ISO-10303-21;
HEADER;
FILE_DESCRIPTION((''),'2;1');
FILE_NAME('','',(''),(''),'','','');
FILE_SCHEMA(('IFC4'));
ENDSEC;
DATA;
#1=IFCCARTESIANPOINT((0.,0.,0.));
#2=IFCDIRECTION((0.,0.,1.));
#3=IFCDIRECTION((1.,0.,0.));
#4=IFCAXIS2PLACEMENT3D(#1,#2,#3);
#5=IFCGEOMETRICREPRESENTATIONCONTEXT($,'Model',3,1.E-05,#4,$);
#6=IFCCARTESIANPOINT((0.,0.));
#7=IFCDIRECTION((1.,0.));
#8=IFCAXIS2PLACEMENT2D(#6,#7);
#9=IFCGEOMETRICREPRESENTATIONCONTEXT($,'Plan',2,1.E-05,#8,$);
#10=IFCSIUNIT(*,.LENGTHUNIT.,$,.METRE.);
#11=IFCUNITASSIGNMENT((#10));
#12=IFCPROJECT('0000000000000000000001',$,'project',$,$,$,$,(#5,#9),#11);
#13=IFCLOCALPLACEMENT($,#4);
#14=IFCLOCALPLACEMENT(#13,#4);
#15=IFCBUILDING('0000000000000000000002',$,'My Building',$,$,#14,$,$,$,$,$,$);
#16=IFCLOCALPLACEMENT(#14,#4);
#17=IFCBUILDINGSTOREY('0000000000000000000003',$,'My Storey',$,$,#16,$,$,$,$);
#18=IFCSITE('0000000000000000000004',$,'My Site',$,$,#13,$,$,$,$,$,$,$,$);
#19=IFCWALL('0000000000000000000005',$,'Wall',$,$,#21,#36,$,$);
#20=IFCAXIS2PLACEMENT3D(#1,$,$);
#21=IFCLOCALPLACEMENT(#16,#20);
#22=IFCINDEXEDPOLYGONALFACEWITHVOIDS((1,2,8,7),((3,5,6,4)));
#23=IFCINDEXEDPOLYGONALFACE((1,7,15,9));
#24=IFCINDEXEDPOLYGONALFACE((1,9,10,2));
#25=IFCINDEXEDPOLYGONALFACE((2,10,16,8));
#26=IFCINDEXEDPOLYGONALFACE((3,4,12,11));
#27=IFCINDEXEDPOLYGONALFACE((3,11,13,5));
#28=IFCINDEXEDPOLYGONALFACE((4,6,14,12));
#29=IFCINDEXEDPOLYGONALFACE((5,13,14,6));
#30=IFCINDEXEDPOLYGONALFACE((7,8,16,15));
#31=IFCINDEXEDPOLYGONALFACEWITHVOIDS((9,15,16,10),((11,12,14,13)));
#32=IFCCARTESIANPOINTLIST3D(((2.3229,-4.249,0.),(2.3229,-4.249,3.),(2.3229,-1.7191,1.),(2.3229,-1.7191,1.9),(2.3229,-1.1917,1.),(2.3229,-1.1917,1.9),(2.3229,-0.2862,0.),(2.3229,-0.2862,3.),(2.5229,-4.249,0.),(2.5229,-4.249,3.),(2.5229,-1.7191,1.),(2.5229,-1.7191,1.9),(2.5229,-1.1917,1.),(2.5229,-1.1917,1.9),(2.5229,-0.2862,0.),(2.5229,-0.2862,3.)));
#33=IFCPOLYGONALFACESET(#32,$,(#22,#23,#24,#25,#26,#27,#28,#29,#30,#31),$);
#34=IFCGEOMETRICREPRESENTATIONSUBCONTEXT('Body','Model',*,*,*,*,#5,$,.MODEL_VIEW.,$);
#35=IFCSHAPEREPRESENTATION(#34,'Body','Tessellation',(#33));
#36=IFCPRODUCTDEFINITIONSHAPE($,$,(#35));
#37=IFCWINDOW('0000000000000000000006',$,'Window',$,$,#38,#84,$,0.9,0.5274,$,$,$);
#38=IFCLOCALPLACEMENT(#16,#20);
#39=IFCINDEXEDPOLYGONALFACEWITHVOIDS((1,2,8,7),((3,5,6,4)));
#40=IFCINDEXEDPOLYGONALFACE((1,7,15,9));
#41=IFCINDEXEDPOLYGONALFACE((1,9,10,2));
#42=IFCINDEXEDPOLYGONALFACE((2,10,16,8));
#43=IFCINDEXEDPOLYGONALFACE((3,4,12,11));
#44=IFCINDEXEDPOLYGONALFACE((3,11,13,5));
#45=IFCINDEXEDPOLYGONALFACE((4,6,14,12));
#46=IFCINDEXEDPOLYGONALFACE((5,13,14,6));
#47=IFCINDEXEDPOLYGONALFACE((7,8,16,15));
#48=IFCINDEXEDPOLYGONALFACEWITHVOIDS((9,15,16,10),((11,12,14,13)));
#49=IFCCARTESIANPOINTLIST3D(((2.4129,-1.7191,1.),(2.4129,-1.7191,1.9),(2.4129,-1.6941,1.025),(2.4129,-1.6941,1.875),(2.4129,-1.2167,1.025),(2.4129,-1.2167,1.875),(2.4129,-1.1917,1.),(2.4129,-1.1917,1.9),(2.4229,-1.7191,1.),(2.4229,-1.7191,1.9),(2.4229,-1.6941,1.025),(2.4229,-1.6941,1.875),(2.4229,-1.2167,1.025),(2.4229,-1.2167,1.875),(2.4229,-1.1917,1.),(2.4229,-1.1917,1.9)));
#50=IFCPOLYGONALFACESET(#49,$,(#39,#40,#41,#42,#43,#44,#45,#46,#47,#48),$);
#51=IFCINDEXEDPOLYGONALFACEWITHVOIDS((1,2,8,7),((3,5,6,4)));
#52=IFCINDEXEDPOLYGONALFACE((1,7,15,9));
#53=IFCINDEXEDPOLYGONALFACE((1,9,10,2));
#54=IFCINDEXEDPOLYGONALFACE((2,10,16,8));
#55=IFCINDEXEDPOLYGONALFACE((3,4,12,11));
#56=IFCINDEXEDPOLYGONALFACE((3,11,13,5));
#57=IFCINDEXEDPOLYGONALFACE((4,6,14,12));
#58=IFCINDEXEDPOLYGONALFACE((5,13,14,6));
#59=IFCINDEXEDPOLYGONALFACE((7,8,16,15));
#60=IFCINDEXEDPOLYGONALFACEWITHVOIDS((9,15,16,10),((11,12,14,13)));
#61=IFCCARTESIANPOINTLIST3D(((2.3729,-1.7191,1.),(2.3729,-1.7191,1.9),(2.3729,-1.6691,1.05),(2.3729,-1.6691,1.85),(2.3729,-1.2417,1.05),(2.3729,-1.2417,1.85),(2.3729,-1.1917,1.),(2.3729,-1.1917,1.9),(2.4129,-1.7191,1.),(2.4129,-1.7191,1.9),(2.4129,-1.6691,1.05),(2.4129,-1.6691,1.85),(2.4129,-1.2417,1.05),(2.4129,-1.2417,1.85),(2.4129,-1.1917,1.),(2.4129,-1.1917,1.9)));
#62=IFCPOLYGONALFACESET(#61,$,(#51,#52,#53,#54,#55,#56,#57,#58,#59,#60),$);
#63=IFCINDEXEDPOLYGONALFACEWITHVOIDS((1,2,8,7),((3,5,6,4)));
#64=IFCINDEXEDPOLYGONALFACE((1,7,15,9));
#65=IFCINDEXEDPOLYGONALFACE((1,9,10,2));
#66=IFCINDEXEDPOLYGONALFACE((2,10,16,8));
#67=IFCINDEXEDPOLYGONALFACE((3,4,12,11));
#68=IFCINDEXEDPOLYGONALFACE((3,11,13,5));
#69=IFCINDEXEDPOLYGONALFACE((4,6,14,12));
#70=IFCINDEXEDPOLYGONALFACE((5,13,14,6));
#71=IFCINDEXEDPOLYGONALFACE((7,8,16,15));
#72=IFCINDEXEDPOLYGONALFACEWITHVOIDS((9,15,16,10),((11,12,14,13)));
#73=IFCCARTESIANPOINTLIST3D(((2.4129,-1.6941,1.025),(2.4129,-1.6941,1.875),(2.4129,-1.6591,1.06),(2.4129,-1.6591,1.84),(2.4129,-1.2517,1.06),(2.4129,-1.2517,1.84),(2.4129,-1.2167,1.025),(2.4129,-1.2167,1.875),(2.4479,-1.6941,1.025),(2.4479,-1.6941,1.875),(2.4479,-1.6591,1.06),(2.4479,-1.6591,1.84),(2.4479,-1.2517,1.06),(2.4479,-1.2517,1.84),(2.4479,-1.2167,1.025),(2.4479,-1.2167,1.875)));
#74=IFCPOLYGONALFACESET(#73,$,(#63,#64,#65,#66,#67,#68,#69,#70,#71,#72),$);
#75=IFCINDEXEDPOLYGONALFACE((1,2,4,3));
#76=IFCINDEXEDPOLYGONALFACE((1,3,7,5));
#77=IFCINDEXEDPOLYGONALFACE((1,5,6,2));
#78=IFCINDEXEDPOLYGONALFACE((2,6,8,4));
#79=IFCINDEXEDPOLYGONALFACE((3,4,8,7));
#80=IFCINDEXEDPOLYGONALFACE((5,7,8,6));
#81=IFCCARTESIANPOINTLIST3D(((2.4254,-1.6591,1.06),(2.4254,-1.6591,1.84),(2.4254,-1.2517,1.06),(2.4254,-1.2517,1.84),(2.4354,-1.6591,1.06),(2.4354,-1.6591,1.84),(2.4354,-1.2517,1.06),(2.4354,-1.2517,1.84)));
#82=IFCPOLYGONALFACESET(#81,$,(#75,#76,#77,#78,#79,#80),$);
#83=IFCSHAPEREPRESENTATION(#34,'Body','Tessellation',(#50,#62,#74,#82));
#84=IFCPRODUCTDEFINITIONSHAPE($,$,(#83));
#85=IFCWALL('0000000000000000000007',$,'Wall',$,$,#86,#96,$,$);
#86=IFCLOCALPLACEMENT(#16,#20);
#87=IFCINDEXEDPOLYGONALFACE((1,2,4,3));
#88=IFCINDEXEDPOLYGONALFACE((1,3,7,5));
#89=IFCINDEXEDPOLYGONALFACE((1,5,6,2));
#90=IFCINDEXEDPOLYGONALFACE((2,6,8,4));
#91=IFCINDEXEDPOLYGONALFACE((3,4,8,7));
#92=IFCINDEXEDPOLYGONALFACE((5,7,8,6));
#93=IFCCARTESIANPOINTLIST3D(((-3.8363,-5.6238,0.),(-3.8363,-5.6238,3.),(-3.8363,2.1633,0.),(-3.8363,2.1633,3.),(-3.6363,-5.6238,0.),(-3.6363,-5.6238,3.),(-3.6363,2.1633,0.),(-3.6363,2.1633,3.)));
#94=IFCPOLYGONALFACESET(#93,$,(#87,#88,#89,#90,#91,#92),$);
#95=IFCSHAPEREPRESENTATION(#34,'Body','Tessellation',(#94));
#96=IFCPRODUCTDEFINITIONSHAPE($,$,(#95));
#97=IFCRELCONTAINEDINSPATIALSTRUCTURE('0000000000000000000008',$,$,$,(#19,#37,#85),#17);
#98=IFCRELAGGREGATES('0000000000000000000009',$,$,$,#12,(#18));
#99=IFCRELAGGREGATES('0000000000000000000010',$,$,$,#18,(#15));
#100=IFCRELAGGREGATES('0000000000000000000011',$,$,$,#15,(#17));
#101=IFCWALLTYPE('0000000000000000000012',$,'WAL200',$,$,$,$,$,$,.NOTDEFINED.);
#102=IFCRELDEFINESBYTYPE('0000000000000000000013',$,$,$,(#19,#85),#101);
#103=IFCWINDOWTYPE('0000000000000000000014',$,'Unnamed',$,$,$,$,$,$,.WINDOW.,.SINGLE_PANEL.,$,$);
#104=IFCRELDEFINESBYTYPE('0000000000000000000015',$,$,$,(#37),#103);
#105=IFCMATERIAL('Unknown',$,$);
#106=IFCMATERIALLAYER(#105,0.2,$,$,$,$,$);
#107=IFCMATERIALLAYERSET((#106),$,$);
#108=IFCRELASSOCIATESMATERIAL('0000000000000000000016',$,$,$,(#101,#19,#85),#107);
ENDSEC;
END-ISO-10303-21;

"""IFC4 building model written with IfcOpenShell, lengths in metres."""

from ifc_helpers import new_model, entity, si_unit, frame, origin_with_axes, origin_2d_with_axis, place, context, subcontext, project, spatial, line, indexed_curve, outline, extrude, shape, source, transform, mapped, material, layer, layer_set, layer_usage, type_object, type_shapes, element, fill, save


model = new_model("IFC4")

# Units and contexts
model_context = context("Model", 3, precision=1e-05, world=origin_with_axes())
plan_context = context("Plan", 2, precision=1e-05, world=origin_2d_with_axis())
body_context_1 = subcontext(model_context, "Body", "Model", "MODEL_VIEW")
body_context_2 = subcontext(plan_context, "Body", "Plan", "PLAN_VIEW")
ifc_project = project(units=[si_unit("LENGTHUNIT", "METRE")], contexts=[model_context, plan_context])

# Site, building, storey
site_placement = place(None, origin_with_axes())
site = spatial("IfcSite", under=ifc_project, at=site_placement, Name="My Site")
building_placement = place(site_placement, origin_with_axes())
building = spatial("IfcBuilding", under=site, at=building_placement, Name="My Building")
storey_placement = place(building_placement, origin_with_axes())
storey = spatial("IfcBuildingStorey", under=building, at=storey_placement, Name="My Storey")

# Shared definitions
ifc_material = material(Name="Unknown")

# Shared definitions
ifc_layer_1 = layer(ifc_material, 0.2)
ifc_layer_set_1 = layer_set([ifc_layer_1])
wall_type_1 = type_object("IfcWallType", Name="WAL200", PredefinedType="NOTDEFINED", material=ifc_layer_set_1)
shared_shape_1 = source(origin_with_axes(), body_context_1, "Body", "SweptSolid", [
    extrude(outline(indexed_curve([(0.0, 0.0), (0.5274, 0.0), (0.5274, 0.9), (0.0, 0.9)], segments=[line(1, 2, 3, 4, 1)])), frame((0.0, -0.6, 0.0), z_axis=(0.0, -1.0, 0.0), x_axis=(1.0, 0.0, 0.0)), (0.0, 0.0, -1.0), 1.2),
])
window_type_1 = type_object("IfcWindowType", Name="Unnamed", PartitioningType="SINGLE_PANEL", PredefinedType="WINDOW")
shared_shape_2 = source(origin_with_axes(), body_context_1, "Body", "SweptSolid", [
    extrude(outline(indexed_curve([(0.0, 0.0), (0.5274, 0.0), (0.5274, 0.9), (0.0, 0.9)], segments=[line(1, 2, 3, 4, 1)]), holes=[indexed_curve([(0.025, 0.025), (0.5024, 0.025), (0.5024, 0.875), (0.025, 0.875)], segments=[line(1, 2, 3, 4, 1)])]), frame((0.0, 0.09, 0.0), z_axis=(0.0, -1.0, 0.0), x_axis=(1.0, 0.0, 0.0)), (0.0, 0.0, -1.0), 0.01),
    extrude(outline(indexed_curve([(0.0, 0.0), (0.5274, 0.0), (0.5274, 0.9), (0.0, 0.9)], segments=[line(1, 2, 3, 4, 1)]), holes=[indexed_curve([(0.05, 0.05), (0.4774, 0.05), (0.4774, 0.85), (0.05, 0.85)], segments=[line(1, 2, 3, 4, 1)])]), frame((0.0, 0.05, 0.0), z_axis=(0.0, -1.0, 0.0), x_axis=(1.0, 0.0, 0.0)), (0.0, 0.0, -1.0), 0.04),
    extrude(outline(indexed_curve([(0.0, 0.0), (0.4774, 0.0), (0.4774, 0.85), (0.0, 0.85)], segments=[line(1, 2, 3, 4, 1)]), holes=[indexed_curve([(0.035, 0.035), (0.4424, 0.035), (0.4424, 0.815), (0.035, 0.815)], segments=[line(1, 2, 3, 4, 1)])]), frame((0.025, 0.09, 0.025), z_axis=(0.0, -1.0, 0.0), x_axis=(1.0, 0.0, 0.0)), (0.0, 0.0, -1.0), 0.035),
    extrude(outline(indexed_curve([(0.035, 0.035), (0.4424, 0.035), (0.4424, 0.815), (0.035, 0.815)], segments=[line(1, 2, 3, 4, 1)])), frame((0.025, 0.1025, 0.025), z_axis=(0.0, -1.0, 0.0), x_axis=(1.0, 0.0, 0.0)), (0.0, 0.0, -1.0), 0.01),
])
shared_shape_3 = source(origin_with_axes(), body_context_2, "Body", "Curve2D", [
    entity("IfcIndexedPolyCurve", entity("IfcCartesianPointList2D", [[0.05, 0.05], [0.4774, 0.05]])),
    entity("IfcIndexedPolyCurve", entity("IfcCartesianPointList2D", [[0.0, 0.1], [0.025, 0.1], [0.025, 0.09], [0.05, 0.09], [0.05, 0.05], [0.0, 0.05]]), [entity("IfcLineIndex", [1, 2, 3, 4, 5, 6, 1])]),
    entity("IfcIndexedPolyCurve", entity("IfcCartesianPointList2D", [[0.5274, 0.1], [0.5024, 0.1], [0.5024, 0.09], [0.4774, 0.09], [0.4774, 0.05], [0.5274, 0.05]]), [entity("IfcLineIndex", [1, 2, 3, 4, 5, 6, 1])]),
    entity("IfcIndexedPolyCurve", entity("IfcCartesianPointList2D", [[0.025, 0.09], [0.06, 0.09], [0.06, 0.125], [0.025, 0.125]]), [entity("IfcLineIndex", [1, 2, 3, 4, 1])]),
    entity("IfcIndexedPolyCurve", entity("IfcCartesianPointList2D", [[0.5024, 0.09], [0.4674, 0.09], [0.4674, 0.125], [0.5024, 0.125]]), [entity("IfcLineIndex", [1, 2, 3, 4, 1])]),
    entity("IfcIndexedPolyCurve", entity("IfcCartesianPointList2D", [[0.06, 0.09], [0.4674, 0.09]])),
    entity("IfcIndexedPolyCurve", entity("IfcCartesianPointList2D", [[0.06, 0.125], [0.4674, 0.125]])),
    entity("IfcIndexedPolyCurve", entity("IfcCartesianPointList2D", [[0.06, 0.1075], [0.4674, 0.1075]])),
])
type_shapes(window_type_1, [shared_shape_2, shared_shape_3])

# Wall, opening, window
ifc_layer_usage_1 = layer_usage(ifc_layer_set_1, "AXIS2", "POSITIVE", 0.0)
wall_1_placement = place(storey_placement, frame((2.5229, -4.249, 0.0), z_axis=(0.0, 0.0, 1.0), x_axis=(0.0, 1.0, 0.0)))
wall_1 = element("IfcWall", 1, at=wall_1_placement, inside=storey, type_object=wall_type_1, material=ifc_layer_usage_1, Name="Wall", context=body_context_1, shape_type="SweptSolid", body=[
    extrude(outline(indexed_curve([(0.0, 0.0), (0.0, 0.2), (3.9628, 0.2), (3.9628, 0.0)], segments=[line(1, 2, 3, 4, 1)])), origin_with_axes(), (0.0, 0.0, 1.0), 3.0),
])
opening_1_placement = place(wall_1_placement, frame((3.0573, 0.2, 1.0), z_axis=(0.0, 0.0, 1.0), x_axis=(-1.0, 0.0, 0.0)))
opening_1 = element("IfcOpeningElement", 2, at=opening_1_placement, cuts=wall_1, PredefinedType="OPENING", context=body_context_1, shape_type="MappedRepresentation", body=[
    mapped(shared_shape_1, transform((0.0, 0.0, 0.0), x_axis=(1.0, 0.0, 0.0), y_axis=(0.0, 1.0, 0.0), z_axis=(0.0, 0.0, 1.0), scale=1.0)),
])
window_1_placement = place(opening_1_placement, origin_with_axes())
window_1 = element("IfcWindow", 3, at=window_1_placement, inside=storey, type_object=window_type_1, Name="Window", OverallHeight=0.9, OverallWidth=0.5274, shapes=[
    shape(body_context_1, "Body", "MappedRepresentation", [mapped(shared_shape_2, transform((0.0, 0.0, 0.0), x_axis=(1.0, 0.0, 0.0), y_axis=(0.0, 1.0, 0.0), z_axis=(0.0, 0.0, 1.0), scale=1.0))]),
    shape(body_context_2, "Body", "MappedRepresentation", [mapped(shared_shape_3, transform((0.0, 0.0, 0.0), x_axis=(1.0, 0.0, 0.0), y_axis=(0.0, 1.0, 0.0), z_axis=(0.0, 0.0, 1.0), scale=1.0))]),
])
fill(opening_1, window_1)

# Wall
ifc_layer_usage_2 = layer_usage(ifc_layer_set_1, "AXIS2", "POSITIVE", 0.0)
wall_2_placement = place(storey_placement, frame((-3.6363, -5.6238, 0.0), z_axis=(0.0, 0.0, 1.0), x_axis=(0.0, 1.0, 0.0)))
element("IfcWall", 4, at=wall_2_placement, inside=storey, type_object=wall_type_1, material=ifc_layer_usage_2, Name="Wall", context=body_context_1, shape_type="SweptSolid", body=[
    extrude(outline(indexed_curve([(0.0, 0.0), (0.0, 0.2), (7.7871, 0.2), (7.7871, 0.0)], segments=[line(1, 2, 3, 4, 1)])), origin_with_axes(), (0.0, 0.0, 1.0), 3.0),
])

save(model, "model.ifc")
